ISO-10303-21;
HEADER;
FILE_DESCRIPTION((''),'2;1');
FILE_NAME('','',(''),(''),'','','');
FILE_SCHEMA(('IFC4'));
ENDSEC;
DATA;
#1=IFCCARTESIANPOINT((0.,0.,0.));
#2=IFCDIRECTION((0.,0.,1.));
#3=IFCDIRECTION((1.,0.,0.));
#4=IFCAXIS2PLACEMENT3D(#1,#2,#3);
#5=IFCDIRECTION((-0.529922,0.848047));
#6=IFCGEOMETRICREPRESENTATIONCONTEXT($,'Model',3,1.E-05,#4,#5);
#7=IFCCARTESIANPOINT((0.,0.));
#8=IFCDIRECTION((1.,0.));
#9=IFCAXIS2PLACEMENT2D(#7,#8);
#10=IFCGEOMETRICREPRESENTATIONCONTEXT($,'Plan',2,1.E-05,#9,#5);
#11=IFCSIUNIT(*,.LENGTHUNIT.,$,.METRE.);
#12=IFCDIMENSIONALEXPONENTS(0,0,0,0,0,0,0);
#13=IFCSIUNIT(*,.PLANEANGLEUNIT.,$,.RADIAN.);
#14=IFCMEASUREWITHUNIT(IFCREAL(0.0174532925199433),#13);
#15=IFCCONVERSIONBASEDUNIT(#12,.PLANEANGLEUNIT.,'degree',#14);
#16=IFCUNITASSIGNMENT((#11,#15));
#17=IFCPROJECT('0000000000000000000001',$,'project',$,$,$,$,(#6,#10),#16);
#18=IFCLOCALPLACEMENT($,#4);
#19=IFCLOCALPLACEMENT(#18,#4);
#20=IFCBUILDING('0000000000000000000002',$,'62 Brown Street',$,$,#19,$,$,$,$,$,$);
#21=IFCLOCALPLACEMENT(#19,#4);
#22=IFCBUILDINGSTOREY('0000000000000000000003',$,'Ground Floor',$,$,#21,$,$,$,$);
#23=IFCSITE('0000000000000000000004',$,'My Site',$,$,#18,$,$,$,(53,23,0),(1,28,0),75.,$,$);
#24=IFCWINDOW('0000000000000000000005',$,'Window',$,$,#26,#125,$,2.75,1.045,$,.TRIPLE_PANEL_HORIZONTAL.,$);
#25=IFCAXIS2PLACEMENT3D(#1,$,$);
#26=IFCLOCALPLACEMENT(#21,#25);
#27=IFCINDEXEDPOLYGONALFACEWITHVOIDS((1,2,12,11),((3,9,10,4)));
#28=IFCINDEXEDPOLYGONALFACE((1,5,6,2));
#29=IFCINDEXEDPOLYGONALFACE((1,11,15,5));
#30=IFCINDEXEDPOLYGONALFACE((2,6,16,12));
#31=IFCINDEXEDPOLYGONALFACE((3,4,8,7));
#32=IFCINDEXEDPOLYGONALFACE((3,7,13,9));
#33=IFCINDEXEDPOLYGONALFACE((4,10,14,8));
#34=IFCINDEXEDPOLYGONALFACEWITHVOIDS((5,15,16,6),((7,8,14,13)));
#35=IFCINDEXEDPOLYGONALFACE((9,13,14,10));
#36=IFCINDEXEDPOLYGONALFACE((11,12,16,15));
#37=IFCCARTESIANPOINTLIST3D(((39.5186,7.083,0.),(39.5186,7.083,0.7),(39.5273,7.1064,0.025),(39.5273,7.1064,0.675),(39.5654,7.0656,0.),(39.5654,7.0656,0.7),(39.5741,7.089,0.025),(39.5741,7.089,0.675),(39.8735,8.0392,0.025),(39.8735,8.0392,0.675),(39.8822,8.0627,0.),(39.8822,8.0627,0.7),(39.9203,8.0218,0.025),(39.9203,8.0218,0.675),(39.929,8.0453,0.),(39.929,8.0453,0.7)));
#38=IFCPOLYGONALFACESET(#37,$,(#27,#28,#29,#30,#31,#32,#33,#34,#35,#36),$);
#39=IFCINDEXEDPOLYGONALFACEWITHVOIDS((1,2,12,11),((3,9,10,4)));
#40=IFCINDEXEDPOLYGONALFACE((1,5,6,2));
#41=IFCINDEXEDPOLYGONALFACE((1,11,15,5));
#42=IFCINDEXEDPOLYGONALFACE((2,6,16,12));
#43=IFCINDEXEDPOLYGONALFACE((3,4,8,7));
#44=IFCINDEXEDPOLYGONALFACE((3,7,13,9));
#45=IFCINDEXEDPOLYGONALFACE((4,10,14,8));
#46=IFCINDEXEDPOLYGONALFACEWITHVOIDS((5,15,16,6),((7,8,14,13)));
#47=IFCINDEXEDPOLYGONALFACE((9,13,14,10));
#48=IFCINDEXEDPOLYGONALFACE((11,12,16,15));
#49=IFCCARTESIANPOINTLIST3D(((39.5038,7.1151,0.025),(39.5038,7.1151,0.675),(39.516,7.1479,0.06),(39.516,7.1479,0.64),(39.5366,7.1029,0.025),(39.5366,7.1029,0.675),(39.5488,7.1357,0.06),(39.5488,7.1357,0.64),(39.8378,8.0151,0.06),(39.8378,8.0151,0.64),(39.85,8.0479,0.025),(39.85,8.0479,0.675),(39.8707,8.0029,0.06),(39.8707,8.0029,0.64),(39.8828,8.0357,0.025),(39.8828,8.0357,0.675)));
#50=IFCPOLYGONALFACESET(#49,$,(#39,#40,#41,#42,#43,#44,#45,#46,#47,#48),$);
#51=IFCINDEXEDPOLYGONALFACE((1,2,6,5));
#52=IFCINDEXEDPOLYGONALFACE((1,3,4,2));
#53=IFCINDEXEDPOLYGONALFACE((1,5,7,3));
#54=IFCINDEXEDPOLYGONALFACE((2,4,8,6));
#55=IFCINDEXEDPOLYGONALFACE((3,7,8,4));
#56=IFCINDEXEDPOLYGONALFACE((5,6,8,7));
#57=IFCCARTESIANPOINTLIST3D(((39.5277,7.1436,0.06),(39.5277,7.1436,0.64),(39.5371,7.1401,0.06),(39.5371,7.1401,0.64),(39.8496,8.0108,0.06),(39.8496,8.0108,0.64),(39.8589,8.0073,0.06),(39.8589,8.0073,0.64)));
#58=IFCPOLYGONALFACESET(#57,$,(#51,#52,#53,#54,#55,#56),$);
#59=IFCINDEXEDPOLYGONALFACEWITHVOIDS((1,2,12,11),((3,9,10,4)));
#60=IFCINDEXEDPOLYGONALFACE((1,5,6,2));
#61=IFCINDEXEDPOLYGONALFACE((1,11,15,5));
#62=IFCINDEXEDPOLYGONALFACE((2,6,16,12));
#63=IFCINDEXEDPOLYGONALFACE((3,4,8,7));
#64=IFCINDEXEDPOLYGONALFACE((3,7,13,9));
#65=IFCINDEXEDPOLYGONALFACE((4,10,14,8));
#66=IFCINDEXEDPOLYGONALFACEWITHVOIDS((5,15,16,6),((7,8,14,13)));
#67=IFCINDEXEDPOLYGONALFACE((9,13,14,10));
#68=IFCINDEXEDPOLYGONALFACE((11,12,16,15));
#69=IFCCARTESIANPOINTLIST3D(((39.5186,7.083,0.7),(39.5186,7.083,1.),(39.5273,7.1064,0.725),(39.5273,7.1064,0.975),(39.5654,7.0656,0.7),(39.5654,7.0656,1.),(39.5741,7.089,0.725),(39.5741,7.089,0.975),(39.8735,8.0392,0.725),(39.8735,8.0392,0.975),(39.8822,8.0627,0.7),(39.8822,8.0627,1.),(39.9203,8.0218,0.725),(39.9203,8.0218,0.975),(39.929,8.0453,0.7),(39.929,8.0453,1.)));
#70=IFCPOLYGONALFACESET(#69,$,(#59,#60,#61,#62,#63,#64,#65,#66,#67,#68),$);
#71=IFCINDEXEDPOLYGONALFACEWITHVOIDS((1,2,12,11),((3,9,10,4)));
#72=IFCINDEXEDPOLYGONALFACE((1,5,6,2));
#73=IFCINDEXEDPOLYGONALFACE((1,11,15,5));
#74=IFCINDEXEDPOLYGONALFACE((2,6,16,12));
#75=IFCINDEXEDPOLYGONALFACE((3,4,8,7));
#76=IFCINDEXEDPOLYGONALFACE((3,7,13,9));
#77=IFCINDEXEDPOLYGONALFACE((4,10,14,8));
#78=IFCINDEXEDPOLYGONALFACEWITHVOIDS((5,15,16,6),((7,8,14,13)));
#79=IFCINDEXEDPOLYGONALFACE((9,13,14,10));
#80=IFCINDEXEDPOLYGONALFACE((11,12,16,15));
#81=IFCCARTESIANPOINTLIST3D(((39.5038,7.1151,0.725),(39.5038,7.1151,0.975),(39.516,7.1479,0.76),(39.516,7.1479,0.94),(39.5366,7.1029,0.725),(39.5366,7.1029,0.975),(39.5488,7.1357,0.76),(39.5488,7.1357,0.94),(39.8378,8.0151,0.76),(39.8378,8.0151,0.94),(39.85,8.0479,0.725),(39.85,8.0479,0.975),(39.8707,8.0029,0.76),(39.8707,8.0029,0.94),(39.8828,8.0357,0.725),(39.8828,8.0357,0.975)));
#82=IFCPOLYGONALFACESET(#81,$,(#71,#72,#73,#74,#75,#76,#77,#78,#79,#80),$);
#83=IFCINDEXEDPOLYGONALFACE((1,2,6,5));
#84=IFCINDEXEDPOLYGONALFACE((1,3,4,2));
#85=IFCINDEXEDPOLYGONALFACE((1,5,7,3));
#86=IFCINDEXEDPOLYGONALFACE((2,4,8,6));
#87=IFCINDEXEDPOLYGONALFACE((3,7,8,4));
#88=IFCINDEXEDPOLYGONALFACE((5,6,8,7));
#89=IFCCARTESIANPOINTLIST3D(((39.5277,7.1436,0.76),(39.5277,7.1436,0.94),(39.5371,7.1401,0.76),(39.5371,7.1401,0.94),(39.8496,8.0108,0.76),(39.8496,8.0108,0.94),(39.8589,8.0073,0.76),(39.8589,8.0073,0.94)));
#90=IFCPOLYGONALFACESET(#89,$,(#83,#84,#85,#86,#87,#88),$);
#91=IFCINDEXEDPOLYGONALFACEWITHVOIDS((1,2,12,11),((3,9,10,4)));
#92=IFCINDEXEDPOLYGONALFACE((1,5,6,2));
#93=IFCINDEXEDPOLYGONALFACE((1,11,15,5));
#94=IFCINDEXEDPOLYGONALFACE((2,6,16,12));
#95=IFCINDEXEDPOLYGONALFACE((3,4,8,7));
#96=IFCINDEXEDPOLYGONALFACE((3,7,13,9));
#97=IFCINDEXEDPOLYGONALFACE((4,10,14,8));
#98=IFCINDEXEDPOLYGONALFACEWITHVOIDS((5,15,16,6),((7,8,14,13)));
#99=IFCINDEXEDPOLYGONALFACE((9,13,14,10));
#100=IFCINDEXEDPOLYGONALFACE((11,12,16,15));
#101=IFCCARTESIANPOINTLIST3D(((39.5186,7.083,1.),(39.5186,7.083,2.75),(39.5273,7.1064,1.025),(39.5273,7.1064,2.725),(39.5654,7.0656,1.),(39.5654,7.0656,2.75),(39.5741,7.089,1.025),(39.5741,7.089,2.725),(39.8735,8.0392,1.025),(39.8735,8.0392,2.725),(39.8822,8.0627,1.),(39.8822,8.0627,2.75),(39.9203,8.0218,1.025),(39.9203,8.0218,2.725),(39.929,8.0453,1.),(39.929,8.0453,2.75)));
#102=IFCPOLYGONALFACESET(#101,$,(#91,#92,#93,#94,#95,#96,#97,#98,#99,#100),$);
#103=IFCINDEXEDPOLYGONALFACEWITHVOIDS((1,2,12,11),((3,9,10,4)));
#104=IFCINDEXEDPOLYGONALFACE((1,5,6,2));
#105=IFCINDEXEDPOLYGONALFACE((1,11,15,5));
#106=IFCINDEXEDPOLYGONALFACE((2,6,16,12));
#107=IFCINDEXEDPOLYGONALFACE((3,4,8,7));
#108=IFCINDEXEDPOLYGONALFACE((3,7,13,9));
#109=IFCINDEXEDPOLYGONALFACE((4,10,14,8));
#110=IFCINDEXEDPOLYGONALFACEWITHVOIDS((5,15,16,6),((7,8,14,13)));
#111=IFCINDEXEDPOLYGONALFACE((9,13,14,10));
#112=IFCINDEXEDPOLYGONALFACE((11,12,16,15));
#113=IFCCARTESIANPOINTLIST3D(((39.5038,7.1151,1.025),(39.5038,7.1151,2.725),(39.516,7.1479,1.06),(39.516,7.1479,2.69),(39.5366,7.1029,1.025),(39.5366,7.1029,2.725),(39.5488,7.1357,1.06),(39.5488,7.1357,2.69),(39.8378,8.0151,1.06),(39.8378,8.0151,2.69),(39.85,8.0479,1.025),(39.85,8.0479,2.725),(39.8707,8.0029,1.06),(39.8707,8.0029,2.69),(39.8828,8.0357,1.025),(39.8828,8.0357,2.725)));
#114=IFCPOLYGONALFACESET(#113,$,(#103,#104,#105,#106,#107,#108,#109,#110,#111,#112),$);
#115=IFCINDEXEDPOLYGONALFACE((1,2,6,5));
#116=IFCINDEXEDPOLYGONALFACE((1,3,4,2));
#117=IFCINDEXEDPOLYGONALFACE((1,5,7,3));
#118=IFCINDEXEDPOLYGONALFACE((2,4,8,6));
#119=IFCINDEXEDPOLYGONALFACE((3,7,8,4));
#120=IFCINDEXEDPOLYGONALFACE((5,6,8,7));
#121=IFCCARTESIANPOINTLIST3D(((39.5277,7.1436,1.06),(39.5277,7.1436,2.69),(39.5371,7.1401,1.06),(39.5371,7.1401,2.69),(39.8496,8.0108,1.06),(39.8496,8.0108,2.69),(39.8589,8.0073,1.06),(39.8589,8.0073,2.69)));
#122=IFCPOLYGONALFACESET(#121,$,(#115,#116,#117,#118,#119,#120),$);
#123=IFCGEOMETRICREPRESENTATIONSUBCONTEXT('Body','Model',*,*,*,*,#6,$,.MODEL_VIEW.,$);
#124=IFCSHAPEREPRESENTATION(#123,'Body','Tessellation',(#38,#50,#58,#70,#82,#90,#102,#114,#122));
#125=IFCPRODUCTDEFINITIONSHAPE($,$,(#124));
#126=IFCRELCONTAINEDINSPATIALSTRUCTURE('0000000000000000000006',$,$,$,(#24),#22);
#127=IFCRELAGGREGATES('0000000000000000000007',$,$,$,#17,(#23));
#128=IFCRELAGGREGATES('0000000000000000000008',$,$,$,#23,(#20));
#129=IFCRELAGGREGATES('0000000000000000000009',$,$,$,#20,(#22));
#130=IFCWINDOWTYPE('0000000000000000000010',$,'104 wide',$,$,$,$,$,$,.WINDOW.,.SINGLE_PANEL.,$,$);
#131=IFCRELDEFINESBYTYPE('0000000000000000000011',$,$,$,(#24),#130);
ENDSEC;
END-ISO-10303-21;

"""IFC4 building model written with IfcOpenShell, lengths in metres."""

from ifc_helpers import new_model, entity, si_unit, converted_unit, direction, frame, origin_with_axes, origin_2d_with_axis, place, context, subcontext, project, spatial, line, indexed_curve, outline, extrude, shape, source, transform, mapped, type_object, type_shapes, element, save


model = new_model("IFC4")

# Units and contexts
model_context = context("Model", 3, precision=1e-05, world=origin_with_axes(), true_north=direction((-0.529922, 0.848047)))
plan_context = context("Plan", 2, precision=1e-05, world=origin_2d_with_axis(), true_north=direction((-0.529922, 0.848047)))
body_context_1 = subcontext(model_context, "Body", "Model", "MODEL_VIEW")
body_context_2 = subcontext(plan_context, "Body", "Plan", "PLAN_VIEW")
ifc_project = project(units=[si_unit("LENGTHUNIT", "METRE"), converted_unit("PLANEANGLEUNIT", "degree", entity("IfcReal", 0.0174532925199433), si_unit("PLANEANGLEUNIT", "RADIAN"), dimensions=[0, 0, 0, 0, 0, 0, 0])], contexts=[model_context, plan_context])

# Site, building, storey
site_placement = place(None, origin_with_axes())
site = spatial("IfcSite", under=ifc_project, at=site_placement, Name="My Site", RefLatitude=(53, 23, 0), RefLongitude=(1, 28, 0), RefElevation=75.0)
building_placement = place(site_placement, origin_with_axes())
building = spatial("IfcBuilding", under=site, at=building_placement, Name="62 Brown Street")
storey_placement = place(building_placement, origin_with_axes())
storey = spatial("IfcBuildingStorey", under=building, at=storey_placement, Name="Ground Floor")

# Window
window_type_1 = type_object("IfcWindowType", Name="104 wide", PartitioningType="SINGLE_PANEL", PredefinedType="WINDOW")
shared_shape_1 = source(origin_with_axes(), body_context_1, "Body", "SweptSolid", [
    extrude(outline(indexed_curve([(0.0, 0.0), (1.045, 0.0), (1.045, 0.7), (0.0, 0.7)], segments=[line(1, 2, 3, 4, 1)]), holes=[indexed_curve([(0.025, 0.025), (1.02, 0.025), (1.02, 0.675), (0.025, 0.675)], segments=[line(1, 2, 3, 4, 1)])]), frame((0.0, 0.15, 0.0), z_axis=(0.0, -1.0, 0.0), x_axis=(1.0, 0.0, 0.0)), (0.0, 0.0, -1.0), 0.05),
    extrude(outline(indexed_curve([(0.0, 0.0), (0.995, 0.0), (0.995, 0.65), (0.0, 0.65)], segments=[line(1, 2, 3, 4, 1)]), holes=[indexed_curve([(0.035, 0.035), (0.96, 0.035), (0.96, 0.615), (0.035, 0.615)], segments=[line(1, 2, 3, 4, 1)])]), frame((0.025, 0.19, 0.025), z_axis=(0.0, -1.0, 0.0), x_axis=(1.0, 0.0, 0.0)), (0.0, 0.0, -1.0), 0.035),
    extrude(outline(indexed_curve([(0.035, 0.035), (0.96, 0.035), (0.96, 0.615), (0.035, 0.615)], segments=[line(1, 2, 3, 4, 1)])), frame((0.025, 0.2025, 0.025), z_axis=(0.0, -1.0, 0.0), x_axis=(1.0, 0.0, 0.0)), (0.0, 0.0, -1.0), 0.01),
    extrude(outline(indexed_curve([(0.0, 0.0), (1.045, 0.0), (1.045, 0.3), (0.0, 0.3)], segments=[line(1, 2, 3, 4, 1)]), holes=[indexed_curve([(0.025, 0.025), (1.02, 0.025), (1.02, 0.275), (0.025, 0.275)], segments=[line(1, 2, 3, 4, 1)])]), frame((0.0, 0.15, 0.7), z_axis=(0.0, -1.0, 0.0), x_axis=(1.0, 0.0, 0.0)), (0.0, 0.0, -1.0), 0.05),
    extrude(outline(indexed_curve([(0.0, 0.0), (0.995, 0.0), (0.995, 0.25), (0.0, 0.25)], segments=[line(1, 2, 3, 4, 1)]), holes=[indexed_curve([(0.035, 0.035), (0.96, 0.035), (0.96, 0.215), (0.035, 0.215)], segments=[line(1, 2, 3, 4, 1)])]), frame((0.025, 0.19, 0.725), z_axis=(0.0, -1.0, 0.0), x_axis=(1.0, 0.0, 0.0)), (0.0, 0.0, -1.0), 0.035),
    extrude(outline(indexed_curve([(0.035, 0.035), (0.96, 0.035), (0.96, 0.215), (0.035, 0.215)], segments=[line(1, 2, 3, 4, 1)])), frame((0.025, 0.2025, 0.725), z_axis=(0.0, -1.0, 0.0), x_axis=(1.0, 0.0, 0.0)), (0.0, 0.0, -1.0), 0.01),
    extrude(outline(indexed_curve([(0.0, 0.0), (1.045, 0.0), (1.045, 1.75), (0.0, 1.75)], segments=[line(1, 2, 3, 4, 1)]), holes=[indexed_curve([(0.025, 0.025), (1.02, 0.025), (1.02, 1.725), (0.025, 1.725)], segments=[line(1, 2, 3, 4, 1)])]), frame((0.0, 0.15, 1.0), z_axis=(0.0, -1.0, 0.0), x_axis=(1.0, 0.0, 0.0)), (0.0, 0.0, -1.0), 0.05),
    extrude(outline(indexed_curve([(0.0, 0.0), (0.995, 0.0), (0.995, 1.7), (0.0, 1.7)], segments=[line(1, 2, 3, 4, 1)]), holes=[indexed_curve([(0.035, 0.035), (0.96, 0.035), (0.96, 1.665), (0.035, 1.665)], segments=[line(1, 2, 3, 4, 1)])]), frame((0.025, 0.19, 1.025), z_axis=(0.0, -1.0, 0.0), x_axis=(1.0, 0.0, 0.0)), (0.0, 0.0, -1.0), 0.035),
    extrude(outline(indexed_curve([(0.035, 0.035), (0.96, 0.035), (0.96, 1.665), (0.035, 1.665)], segments=[line(1, 2, 3, 4, 1)])), frame((0.025, 0.2025, 1.025), z_axis=(0.0, -1.0, 0.0), x_axis=(1.0, 0.0, 0.0)), (0.0, 0.0, -1.0), 0.01),
])
shared_shape_2 = source(origin_with_axes(), body_context_2, "Body", "Curve2D", [
    entity("IfcIndexedPolyCurve", entity("IfcCartesianPointList2D", [[0.025, 0.15], [1.02, 0.15]])),
    entity("IfcIndexedPolyCurve", entity("IfcCartesianPointList2D", [[0.0, 0.2], [0.025, 0.2], [0.025, 0.15], [0.0, 0.15]]), [entity("IfcLineIndex", [1, 2, 3, 4, 1])]),
    entity("IfcIndexedPolyCurve", entity("IfcCartesianPointList2D", [[1.045, 0.2], [1.02, 0.2], [1.02, 0.15], [1.045, 0.15]]), [entity("IfcLineIndex", [1, 2, 3, 4, 1])]),
    entity("IfcIndexedPolyCurve", entity("IfcCartesianPointList2D", [[0.025, 0.19], [0.06, 0.19], [0.06, 0.225], [0.025, 0.225]]), [entity("IfcLineIndex", [1, 2, 3, 4, 1])]),
    entity("IfcIndexedPolyCurve", entity("IfcCartesianPointList2D", [[1.02, 0.19], [0.985, 0.19], [0.985, 0.225], [1.02, 0.225]]), [entity("IfcLineIndex", [1, 2, 3, 4, 1])]),
    entity("IfcIndexedPolyCurve", entity("IfcCartesianPointList2D", [[0.06, 0.19], [0.985, 0.19]])),
    entity("IfcIndexedPolyCurve", entity("IfcCartesianPointList2D", [[0.06, 0.225], [0.985, 0.225]])),
    entity("IfcIndexedPolyCurve", entity("IfcCartesianPointList2D", [[0.06, 0.2075], [0.985, 0.2075]])),
])
type_shapes(window_type_1, [shared_shape_1, shared_shape_2])
placement_1 = place(storey_placement, frame((39.024, 5.1755, 0.0), z_axis=(0.0, 0.0, 1.0), x_axis=(0.347944, 0.937515, 0.0)))
placement_2 = place(placement_1, frame((1.9604, 0.0, 0.0), z_axis=(0.0, 0.0, 1.0), x_axis=(1.0, 0.0, 0.0)))
for number, where, z_axis, x_axis, name in (
    (1, (0.0, 0.0, 0.0), (0.0, 0.0, 1.0), (1.0, 0.0, 0.0), "Window"),
):
    element("IfcWindow", number, at=place(placement_2, frame(where, z_axis=z_axis, x_axis=x_axis)), inside=storey, type_object=window_type_1, Name=name, OverallHeight=2.75, OverallWidth=1.045, PartitioningType="TRIPLE_PANEL_HORIZONTAL", shapes=[
        shape(body_context_1, "Body", "MappedRepresentation", [mapped(shared_shape_1, transform((0.0, 0.0, 0.0), x_axis=(1.0, 0.0, 0.0), y_axis=(0.0, 1.0, 0.0), z_axis=(0.0, 0.0, 1.0), scale=1.0))]),
        shape(body_context_2, "Body", "MappedRepresentation", [mapped(shared_shape_2, transform((0.0, 0.0, 0.0), x_axis=(1.0, 0.0, 0.0), y_axis=(0.0, 1.0, 0.0), z_axis=(0.0, 0.0, 1.0), scale=1.0))]),
    ])

save(model, "model.ifc")
